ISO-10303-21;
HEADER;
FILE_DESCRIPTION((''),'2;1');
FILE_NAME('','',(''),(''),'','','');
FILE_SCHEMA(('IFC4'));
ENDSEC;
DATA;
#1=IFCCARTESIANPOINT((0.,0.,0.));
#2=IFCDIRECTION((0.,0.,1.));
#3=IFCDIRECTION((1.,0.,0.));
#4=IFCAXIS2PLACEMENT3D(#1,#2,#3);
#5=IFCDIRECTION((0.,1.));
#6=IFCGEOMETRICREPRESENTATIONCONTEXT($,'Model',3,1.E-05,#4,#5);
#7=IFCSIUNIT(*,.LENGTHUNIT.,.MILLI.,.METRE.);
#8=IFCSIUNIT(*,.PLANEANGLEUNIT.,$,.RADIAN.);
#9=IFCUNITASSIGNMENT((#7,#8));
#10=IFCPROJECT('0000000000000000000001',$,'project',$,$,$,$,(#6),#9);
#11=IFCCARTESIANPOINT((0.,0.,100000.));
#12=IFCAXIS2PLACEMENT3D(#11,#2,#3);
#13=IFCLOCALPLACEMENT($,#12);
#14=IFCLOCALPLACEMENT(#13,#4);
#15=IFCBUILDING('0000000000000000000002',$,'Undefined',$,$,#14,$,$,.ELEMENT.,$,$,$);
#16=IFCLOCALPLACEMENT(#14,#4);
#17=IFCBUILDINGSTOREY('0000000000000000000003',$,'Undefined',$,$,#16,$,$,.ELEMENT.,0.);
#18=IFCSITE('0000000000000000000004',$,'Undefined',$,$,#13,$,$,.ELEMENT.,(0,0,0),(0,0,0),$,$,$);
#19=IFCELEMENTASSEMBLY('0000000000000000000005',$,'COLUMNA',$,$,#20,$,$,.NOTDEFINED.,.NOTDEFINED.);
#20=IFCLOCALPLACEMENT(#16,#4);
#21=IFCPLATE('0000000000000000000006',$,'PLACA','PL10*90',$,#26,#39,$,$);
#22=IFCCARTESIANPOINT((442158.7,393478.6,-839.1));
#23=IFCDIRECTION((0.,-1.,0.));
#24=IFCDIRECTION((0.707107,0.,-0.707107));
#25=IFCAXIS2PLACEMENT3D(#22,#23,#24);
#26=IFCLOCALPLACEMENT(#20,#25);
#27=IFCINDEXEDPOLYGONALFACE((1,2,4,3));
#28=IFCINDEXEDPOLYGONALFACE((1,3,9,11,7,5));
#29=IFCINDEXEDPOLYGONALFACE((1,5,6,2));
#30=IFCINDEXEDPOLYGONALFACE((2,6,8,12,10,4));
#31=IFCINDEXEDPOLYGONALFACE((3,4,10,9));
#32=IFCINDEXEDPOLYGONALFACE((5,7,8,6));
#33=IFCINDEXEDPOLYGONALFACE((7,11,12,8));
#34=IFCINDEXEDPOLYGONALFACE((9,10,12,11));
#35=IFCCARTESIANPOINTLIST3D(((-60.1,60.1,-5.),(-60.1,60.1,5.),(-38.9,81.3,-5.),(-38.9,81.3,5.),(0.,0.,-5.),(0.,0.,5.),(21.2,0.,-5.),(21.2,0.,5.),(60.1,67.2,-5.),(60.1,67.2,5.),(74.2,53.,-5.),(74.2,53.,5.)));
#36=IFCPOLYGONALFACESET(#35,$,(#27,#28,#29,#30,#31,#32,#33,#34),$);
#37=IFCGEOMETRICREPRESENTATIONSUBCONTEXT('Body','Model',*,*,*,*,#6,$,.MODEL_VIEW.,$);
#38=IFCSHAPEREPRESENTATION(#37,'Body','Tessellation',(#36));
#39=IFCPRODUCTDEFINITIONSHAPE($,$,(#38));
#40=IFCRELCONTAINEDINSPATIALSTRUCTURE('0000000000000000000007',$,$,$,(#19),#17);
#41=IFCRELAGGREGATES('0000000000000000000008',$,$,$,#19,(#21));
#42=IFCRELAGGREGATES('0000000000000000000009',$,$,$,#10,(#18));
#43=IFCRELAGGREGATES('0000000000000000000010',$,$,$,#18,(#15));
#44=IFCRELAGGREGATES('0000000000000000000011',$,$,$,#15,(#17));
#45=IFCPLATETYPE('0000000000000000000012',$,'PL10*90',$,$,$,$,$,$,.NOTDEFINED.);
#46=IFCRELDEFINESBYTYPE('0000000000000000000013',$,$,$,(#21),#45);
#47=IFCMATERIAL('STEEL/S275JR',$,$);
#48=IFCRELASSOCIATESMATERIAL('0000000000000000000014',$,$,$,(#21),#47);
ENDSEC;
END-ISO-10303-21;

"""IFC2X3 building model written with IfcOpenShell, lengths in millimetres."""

from ifc_helpers import new_model, si_unit, direction, frame, origin_with_axes, place, context, subcontext, project, spatial, polyline, outline, extrude, material, type_object, element, aggregate, save


model = new_model("IFC2X3")

# Units and contexts
model_context = context("Model", 3, precision=1e-05, world=origin_with_axes(), true_north=direction((0.0, 1.0)))
body_context = subcontext(model_context, "Body", "Model", "MODEL_VIEW")
ifc_project = project(units=[si_unit("LENGTHUNIT", "METRE", prefix="MILLI"), si_unit("PLANEANGLEUNIT", "RADIAN")], contexts=[model_context])

# Site, building, storey
site_placement = place(None, frame((0.0, 0.0, 100000.0), z_axis=(0.0, 0.0, 1.0), x_axis=(1.0, 0.0, 0.0)))
site = spatial("IfcSite", under=ifc_project, at=site_placement, Name="Undefined", CompositionType="ELEMENT", RefLatitude=(0, 0, 0), RefLongitude=(0, 0, 0))
building_placement = place(site_placement, origin_with_axes())
building = spatial("IfcBuilding", under=site, at=building_placement, Name="Undefined", CompositionType="ELEMENT")
storey_placement = place(building_placement, origin_with_axes())
storey = spatial("IfcBuildingStorey", under=building, at=storey_placement, Name="Undefined", CompositionType="ELEMENT", Elevation=0.0)

# Shared definitions
ifc_material_1 = material(Name="STEEL/S275JR")

# Element assembly, plate
assembly_1_placement = place(storey_placement, origin_with_axes())
assembly_1 = element("IfcElementAssembly", 1, at=assembly_1_placement, inside=storey, Name="COLUMNA", AssemblyPlace="NOTDEFINED", PredefinedType="NOTDEFINED")
plate_type = type_object("IfcPlateType", Name="PL10*90", PredefinedType="NOTDEFINED")
plate_placement = place(assembly_1_placement, frame((442158.7, 393478.6, -839.1), z_axis=(0.0, -1.0, 0.0), x_axis=(0.707107, 0.0, -0.707107)))
plate = element("IfcPlate", 2, at=plate_placement, type_object=plate_type, material=ifc_material_1, Name="PLACA", Description="PL10*90", context=body_context, shape_type="SweptSolid", body=[
    extrude(outline(polyline([(0.0, 0.0), (21.2, 0.0), (74.2, 53.0), (60.1, 67.2), (-38.9, 81.3), (-60.1, 60.1), (0.0, 0.0)])), frame((0.0, 0.0, -5.0), z_axis=(0.0, 0.0, 1.0), x_axis=(1.0, 0.0, 0.0)), (0.0, 0.0, 1.0), 10.0),
])
aggregate(assembly_1, [plate])

save(model, "model.ifc")
